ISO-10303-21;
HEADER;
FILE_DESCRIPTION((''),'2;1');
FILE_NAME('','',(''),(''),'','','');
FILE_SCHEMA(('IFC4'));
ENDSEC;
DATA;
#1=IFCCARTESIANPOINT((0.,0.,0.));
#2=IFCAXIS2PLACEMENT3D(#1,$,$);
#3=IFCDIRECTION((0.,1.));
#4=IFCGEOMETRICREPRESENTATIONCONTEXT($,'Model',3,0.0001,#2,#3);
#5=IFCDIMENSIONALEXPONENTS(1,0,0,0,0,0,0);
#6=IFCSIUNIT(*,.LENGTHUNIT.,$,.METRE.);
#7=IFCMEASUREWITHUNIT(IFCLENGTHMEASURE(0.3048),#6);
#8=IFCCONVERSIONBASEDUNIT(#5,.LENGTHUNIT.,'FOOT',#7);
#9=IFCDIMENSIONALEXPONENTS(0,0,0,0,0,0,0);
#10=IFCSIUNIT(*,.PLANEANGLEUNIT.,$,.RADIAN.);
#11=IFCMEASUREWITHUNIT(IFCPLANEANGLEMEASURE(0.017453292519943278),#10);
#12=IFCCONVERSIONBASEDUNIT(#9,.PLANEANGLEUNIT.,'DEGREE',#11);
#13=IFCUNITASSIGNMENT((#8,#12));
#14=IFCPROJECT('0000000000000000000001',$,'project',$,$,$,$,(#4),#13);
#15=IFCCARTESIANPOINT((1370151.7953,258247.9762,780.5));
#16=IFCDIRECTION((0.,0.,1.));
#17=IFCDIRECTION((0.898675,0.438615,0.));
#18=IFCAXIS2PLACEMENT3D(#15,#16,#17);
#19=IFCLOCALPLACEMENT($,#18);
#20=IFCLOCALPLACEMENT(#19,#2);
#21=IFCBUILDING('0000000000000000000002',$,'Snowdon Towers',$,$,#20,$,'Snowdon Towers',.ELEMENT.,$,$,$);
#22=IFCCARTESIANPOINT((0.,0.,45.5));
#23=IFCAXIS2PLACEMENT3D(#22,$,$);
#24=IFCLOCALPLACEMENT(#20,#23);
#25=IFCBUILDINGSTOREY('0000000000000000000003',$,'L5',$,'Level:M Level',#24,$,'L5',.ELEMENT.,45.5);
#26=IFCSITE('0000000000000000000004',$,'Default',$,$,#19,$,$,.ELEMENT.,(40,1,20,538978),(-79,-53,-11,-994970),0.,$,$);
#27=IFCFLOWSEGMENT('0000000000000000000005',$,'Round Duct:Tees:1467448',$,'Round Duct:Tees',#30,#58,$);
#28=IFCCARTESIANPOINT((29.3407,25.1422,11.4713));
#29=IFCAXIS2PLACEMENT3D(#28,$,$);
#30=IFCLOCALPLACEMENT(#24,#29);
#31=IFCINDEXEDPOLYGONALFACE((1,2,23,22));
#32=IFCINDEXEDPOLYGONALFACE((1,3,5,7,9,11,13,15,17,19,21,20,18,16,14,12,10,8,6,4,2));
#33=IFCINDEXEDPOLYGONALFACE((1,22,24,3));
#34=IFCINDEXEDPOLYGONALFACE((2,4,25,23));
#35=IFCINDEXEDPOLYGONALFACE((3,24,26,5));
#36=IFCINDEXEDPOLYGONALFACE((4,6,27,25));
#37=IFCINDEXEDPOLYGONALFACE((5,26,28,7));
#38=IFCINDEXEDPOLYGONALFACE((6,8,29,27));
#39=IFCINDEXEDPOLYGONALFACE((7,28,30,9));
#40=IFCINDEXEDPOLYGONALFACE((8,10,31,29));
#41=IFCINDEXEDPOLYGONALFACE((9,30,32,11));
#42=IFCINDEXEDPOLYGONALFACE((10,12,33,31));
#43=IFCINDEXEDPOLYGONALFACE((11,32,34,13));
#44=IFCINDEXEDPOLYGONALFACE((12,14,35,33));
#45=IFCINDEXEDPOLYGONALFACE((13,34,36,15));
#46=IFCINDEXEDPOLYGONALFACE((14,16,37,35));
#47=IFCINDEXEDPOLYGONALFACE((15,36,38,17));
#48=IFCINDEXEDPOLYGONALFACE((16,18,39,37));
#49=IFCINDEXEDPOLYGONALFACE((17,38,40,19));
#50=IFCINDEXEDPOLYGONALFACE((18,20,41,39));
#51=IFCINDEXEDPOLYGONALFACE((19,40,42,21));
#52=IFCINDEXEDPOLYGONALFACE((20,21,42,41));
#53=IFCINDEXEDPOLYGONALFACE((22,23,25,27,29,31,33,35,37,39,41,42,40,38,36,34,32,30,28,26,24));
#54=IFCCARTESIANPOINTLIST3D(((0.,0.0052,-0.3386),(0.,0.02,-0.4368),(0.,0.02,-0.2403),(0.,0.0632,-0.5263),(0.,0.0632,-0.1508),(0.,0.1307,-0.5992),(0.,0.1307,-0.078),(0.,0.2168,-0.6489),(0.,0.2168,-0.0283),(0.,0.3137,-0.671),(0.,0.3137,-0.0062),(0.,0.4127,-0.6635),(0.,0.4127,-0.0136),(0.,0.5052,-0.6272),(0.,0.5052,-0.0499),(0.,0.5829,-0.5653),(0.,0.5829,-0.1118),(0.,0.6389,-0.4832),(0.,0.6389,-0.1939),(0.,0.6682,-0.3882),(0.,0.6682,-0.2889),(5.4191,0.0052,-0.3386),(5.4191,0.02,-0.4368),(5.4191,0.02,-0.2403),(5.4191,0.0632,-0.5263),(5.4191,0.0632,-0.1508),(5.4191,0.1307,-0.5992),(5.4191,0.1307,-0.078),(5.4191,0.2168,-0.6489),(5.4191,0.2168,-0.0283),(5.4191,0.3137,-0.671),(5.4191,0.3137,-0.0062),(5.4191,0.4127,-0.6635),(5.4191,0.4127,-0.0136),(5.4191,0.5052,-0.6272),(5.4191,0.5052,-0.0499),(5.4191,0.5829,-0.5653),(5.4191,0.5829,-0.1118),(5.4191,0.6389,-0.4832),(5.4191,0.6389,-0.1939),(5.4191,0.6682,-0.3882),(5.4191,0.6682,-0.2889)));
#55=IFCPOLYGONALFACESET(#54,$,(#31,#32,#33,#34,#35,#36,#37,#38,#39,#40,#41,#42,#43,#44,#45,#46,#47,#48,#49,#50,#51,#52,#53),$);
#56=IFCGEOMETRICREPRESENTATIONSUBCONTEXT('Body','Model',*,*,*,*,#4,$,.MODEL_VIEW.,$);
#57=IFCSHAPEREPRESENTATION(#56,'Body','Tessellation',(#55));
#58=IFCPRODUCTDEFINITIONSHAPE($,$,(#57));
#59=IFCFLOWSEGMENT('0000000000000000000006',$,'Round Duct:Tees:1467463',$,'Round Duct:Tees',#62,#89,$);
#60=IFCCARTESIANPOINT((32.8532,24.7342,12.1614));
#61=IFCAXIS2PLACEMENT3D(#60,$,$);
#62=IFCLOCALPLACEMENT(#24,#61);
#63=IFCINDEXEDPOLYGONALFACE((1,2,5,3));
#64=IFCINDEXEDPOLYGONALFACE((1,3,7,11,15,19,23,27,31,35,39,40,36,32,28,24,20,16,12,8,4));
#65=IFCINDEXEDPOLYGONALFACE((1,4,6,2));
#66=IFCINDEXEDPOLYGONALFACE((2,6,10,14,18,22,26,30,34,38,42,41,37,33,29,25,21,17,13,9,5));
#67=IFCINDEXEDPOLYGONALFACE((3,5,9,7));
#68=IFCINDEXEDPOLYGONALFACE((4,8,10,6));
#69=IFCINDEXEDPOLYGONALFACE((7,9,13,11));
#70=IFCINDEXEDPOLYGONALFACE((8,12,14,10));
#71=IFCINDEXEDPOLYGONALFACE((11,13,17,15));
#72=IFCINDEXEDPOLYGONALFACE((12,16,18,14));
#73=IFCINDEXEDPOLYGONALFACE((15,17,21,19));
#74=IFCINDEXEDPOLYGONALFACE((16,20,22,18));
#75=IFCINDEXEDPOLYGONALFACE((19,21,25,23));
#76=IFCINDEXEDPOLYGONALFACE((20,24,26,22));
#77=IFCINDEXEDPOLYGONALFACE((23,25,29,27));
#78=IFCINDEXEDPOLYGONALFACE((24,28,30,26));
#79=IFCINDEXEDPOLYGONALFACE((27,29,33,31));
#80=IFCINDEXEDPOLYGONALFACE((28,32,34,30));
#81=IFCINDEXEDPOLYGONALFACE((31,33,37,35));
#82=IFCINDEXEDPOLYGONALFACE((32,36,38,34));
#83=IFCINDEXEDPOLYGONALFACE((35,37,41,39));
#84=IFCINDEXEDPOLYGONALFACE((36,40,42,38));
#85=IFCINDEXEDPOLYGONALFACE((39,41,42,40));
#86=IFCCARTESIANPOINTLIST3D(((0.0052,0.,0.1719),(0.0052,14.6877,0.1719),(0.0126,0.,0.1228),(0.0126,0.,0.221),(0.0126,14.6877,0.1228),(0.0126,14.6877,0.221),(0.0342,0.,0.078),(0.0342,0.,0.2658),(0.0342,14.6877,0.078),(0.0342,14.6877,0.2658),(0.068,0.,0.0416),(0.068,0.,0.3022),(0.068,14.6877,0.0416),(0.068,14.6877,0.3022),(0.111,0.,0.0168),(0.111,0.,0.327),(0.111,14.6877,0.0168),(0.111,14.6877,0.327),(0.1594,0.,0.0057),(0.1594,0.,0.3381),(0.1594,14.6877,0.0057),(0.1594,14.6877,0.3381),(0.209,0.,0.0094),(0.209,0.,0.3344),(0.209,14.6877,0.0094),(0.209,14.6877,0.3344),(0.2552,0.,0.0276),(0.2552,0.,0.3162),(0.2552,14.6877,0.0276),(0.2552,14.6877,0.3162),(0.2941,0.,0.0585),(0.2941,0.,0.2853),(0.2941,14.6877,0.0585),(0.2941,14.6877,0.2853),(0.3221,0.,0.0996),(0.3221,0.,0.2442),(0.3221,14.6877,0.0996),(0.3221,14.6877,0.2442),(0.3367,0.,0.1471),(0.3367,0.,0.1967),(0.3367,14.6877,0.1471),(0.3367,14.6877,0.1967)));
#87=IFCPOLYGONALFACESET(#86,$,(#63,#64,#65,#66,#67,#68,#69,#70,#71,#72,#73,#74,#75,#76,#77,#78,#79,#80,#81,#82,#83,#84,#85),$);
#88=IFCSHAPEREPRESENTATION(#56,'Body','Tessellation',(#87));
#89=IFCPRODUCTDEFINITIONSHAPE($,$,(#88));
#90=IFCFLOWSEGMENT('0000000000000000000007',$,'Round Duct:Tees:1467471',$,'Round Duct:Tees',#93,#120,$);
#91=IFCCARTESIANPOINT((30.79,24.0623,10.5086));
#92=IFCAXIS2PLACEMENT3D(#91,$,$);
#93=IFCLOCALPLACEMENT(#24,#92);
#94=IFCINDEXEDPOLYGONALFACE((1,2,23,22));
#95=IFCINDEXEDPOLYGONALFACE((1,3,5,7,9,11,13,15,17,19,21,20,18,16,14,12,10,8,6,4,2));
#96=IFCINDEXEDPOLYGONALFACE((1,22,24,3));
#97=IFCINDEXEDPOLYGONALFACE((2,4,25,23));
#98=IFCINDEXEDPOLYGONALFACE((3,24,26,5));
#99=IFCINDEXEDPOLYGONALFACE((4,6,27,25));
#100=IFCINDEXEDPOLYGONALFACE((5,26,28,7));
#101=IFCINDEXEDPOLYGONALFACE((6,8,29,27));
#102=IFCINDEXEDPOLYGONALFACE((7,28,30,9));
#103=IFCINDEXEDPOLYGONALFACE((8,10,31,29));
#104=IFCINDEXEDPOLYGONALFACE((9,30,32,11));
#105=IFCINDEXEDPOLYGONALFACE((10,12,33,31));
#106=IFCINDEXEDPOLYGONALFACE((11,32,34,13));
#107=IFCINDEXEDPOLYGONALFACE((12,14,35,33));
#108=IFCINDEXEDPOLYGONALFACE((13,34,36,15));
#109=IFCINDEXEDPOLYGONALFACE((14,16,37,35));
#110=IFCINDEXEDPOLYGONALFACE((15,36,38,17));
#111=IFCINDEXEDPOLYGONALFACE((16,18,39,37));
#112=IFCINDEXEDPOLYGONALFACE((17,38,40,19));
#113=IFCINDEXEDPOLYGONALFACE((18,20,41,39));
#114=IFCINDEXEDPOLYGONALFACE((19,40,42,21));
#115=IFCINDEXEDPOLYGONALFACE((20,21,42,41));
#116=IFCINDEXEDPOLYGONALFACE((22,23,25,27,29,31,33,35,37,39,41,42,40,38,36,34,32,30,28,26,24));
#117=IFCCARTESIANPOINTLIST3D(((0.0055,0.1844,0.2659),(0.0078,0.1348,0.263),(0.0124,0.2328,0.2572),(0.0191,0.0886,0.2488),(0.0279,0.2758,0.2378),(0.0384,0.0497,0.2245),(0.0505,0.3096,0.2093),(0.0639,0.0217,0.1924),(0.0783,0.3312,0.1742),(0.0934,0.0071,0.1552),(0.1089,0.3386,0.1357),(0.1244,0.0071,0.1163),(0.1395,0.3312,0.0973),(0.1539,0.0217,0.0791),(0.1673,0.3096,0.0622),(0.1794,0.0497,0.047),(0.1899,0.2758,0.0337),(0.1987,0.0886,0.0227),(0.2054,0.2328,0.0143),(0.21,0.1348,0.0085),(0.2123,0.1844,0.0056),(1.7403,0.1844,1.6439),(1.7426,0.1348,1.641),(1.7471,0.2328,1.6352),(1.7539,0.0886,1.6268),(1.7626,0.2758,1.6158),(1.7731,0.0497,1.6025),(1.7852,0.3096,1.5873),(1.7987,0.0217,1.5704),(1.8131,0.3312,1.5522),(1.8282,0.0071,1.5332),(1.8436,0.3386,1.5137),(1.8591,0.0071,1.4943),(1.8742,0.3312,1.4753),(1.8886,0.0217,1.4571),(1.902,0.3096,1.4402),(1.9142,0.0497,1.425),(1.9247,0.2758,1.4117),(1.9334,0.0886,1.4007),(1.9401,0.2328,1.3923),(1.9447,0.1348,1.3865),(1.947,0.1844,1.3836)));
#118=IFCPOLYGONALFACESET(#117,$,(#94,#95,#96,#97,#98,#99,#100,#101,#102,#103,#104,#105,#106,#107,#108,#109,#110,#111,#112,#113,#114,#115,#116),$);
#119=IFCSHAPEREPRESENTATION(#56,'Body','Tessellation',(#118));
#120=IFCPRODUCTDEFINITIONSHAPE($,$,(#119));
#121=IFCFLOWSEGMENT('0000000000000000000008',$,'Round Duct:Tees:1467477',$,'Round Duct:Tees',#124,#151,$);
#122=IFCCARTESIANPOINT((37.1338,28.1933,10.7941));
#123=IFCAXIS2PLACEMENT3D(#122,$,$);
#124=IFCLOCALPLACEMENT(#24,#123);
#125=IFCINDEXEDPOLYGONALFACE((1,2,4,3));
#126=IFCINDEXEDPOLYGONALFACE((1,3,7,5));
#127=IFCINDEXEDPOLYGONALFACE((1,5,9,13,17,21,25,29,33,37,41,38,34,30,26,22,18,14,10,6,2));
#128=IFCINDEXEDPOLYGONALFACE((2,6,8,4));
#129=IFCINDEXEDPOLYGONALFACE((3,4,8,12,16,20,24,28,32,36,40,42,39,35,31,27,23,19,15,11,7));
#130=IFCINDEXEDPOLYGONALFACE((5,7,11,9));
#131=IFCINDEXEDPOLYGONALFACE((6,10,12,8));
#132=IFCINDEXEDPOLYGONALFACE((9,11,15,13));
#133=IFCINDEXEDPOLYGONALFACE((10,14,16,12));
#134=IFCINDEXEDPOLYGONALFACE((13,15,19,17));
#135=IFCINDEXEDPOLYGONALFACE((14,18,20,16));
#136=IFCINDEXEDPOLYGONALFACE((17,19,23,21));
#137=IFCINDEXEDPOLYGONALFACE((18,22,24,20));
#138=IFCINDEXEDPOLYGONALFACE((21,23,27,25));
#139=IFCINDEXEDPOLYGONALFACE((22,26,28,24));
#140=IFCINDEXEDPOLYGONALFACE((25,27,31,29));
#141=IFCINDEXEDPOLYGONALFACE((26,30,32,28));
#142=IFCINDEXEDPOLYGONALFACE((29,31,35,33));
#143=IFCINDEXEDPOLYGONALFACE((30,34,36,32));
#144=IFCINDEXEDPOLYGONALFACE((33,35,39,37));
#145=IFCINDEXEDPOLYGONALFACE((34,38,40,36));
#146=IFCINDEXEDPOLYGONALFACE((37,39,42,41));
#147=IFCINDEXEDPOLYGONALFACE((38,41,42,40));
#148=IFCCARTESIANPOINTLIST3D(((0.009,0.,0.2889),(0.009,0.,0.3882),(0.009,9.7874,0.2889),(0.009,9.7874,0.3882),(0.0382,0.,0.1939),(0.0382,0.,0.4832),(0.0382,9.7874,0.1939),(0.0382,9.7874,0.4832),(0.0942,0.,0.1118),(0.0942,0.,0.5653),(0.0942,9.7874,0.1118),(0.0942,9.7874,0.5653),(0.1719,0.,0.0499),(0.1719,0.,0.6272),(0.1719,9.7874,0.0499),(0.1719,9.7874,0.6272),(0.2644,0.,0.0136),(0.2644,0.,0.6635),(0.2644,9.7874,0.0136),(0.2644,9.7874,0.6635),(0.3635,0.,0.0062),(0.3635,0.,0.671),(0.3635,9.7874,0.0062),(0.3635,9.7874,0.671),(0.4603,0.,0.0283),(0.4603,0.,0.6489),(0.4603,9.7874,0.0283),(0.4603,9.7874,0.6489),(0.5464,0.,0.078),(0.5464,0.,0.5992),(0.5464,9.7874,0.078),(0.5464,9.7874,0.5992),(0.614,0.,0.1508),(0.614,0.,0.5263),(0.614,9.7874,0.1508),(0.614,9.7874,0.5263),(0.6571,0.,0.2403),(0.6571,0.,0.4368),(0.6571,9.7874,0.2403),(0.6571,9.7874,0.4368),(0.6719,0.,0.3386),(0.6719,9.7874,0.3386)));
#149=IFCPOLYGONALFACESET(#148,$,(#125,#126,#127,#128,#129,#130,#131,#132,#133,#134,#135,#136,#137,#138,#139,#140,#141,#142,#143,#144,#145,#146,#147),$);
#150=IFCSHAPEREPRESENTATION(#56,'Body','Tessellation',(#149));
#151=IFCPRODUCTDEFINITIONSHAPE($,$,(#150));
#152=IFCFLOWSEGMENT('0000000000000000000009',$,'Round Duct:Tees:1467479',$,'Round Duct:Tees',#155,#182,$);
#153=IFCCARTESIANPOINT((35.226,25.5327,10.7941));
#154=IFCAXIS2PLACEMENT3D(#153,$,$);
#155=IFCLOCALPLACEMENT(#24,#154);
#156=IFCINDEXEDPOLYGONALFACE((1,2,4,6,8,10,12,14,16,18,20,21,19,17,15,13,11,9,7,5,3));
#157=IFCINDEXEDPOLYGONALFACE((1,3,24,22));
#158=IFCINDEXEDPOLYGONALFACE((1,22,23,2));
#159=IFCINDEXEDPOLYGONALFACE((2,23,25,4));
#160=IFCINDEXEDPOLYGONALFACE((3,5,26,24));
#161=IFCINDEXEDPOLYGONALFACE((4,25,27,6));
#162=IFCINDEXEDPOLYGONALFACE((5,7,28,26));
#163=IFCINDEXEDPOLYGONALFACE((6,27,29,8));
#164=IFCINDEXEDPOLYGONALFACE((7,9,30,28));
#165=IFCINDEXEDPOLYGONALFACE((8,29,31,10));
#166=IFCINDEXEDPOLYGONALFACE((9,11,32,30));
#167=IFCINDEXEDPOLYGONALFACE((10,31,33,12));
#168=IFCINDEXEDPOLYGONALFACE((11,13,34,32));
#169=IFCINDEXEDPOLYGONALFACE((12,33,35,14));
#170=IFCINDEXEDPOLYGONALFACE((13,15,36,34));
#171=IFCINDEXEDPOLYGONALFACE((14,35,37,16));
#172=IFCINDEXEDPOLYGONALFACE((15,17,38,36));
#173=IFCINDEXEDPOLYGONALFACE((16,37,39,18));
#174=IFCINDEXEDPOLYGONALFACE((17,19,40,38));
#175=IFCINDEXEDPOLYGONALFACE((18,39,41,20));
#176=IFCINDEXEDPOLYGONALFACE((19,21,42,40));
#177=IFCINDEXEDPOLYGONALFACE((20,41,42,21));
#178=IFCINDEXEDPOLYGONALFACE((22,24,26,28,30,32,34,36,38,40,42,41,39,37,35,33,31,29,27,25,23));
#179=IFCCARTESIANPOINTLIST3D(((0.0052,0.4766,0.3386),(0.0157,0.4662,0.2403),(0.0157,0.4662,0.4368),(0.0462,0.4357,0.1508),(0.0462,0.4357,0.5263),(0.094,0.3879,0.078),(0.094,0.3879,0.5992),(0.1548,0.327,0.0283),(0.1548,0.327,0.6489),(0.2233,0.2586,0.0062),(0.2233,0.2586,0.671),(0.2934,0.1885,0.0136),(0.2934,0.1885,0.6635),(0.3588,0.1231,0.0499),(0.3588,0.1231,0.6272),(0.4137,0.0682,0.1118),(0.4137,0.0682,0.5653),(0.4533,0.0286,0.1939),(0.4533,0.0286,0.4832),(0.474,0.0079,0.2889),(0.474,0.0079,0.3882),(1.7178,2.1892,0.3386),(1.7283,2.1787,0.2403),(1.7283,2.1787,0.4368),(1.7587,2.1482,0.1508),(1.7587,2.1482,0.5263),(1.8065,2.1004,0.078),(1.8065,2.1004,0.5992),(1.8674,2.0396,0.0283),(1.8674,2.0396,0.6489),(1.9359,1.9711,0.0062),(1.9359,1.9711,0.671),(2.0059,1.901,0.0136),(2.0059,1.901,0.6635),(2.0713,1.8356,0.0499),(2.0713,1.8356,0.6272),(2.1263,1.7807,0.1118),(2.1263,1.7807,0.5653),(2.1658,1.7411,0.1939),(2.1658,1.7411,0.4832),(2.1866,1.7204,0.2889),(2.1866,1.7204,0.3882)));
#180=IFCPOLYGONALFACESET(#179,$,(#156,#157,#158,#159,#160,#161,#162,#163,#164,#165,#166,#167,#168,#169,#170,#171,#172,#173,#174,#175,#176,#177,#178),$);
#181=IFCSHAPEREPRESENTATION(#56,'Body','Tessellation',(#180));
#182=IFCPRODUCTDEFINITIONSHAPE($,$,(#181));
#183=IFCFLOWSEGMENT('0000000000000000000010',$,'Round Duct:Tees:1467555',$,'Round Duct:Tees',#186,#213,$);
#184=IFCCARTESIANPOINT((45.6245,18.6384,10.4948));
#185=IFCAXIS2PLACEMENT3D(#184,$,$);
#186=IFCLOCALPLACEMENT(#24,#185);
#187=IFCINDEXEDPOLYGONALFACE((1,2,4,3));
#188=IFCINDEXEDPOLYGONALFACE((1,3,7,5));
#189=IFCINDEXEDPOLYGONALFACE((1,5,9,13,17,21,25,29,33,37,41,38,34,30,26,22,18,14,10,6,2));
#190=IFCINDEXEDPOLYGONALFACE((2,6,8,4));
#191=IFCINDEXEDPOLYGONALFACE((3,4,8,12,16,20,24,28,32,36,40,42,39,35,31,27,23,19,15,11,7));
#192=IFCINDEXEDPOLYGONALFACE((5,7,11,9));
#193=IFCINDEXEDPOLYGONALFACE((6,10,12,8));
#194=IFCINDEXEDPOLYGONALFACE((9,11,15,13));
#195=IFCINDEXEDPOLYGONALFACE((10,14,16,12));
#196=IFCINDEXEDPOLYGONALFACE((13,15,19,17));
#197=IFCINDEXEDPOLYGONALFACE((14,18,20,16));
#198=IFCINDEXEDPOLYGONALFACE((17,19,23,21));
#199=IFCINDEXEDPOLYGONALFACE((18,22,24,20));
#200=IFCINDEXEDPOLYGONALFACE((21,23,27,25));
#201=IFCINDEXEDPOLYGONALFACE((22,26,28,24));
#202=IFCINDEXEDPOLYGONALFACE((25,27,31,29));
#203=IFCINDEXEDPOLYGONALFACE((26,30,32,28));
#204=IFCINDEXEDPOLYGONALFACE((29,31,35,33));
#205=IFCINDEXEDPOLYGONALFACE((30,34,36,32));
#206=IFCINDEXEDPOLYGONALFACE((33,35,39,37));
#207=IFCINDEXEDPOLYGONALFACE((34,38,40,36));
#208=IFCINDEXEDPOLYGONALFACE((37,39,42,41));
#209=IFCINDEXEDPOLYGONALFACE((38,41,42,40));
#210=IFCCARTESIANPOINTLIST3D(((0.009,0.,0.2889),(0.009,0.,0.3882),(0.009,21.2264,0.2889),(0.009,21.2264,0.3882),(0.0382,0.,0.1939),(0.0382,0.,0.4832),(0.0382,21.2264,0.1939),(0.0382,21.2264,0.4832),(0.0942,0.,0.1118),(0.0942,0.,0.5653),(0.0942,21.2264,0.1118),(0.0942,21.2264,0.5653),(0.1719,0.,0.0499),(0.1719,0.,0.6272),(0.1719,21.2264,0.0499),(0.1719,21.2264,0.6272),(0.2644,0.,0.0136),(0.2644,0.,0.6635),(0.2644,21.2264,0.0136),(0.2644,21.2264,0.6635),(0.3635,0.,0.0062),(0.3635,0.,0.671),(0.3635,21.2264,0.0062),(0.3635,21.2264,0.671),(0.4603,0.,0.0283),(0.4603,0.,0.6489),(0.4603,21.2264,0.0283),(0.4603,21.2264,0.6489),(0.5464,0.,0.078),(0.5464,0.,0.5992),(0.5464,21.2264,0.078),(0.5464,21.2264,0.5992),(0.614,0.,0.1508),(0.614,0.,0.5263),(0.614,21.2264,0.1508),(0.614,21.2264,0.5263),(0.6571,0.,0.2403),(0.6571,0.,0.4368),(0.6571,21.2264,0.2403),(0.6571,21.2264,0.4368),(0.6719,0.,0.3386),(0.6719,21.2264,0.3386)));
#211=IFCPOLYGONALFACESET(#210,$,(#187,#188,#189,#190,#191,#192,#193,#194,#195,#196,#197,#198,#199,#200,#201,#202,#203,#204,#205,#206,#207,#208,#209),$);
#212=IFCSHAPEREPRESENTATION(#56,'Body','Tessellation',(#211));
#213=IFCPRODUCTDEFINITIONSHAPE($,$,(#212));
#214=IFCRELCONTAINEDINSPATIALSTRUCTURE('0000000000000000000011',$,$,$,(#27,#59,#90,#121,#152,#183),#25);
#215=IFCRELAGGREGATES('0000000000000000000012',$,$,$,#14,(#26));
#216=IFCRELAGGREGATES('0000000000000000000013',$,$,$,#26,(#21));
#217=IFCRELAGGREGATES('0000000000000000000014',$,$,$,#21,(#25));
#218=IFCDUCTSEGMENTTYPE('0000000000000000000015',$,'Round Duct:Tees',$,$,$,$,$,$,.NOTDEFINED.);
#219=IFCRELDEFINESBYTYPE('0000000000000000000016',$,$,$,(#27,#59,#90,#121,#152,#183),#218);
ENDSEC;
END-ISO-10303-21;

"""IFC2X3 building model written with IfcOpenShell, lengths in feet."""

from ifc_helpers import new_model, entity, si_unit, converted_unit, direction, frame, frame_2d, origin, origin_2d_with_axis, place, context, subcontext, project, spatial, circle, extrude, type_object, element, save


model = new_model("IFC2X3")

# Units and contexts
model_context = context("Model", 3, precision=0.0001, world=origin(), true_north=direction((0.0, 1.0)))
body_context = subcontext(model_context, "Body", "Model", "MODEL_VIEW")
ifc_project = project(units=[converted_unit("LENGTHUNIT", "FOOT", entity("IfcLengthMeasure", 0.3048), si_unit("LENGTHUNIT", "METRE"), dimensions=[1, 0, 0, 0, 0, 0, 0]), converted_unit("PLANEANGLEUNIT", "DEGREE", entity("IfcPlaneAngleMeasure", 0.017453292519943278), si_unit("PLANEANGLEUNIT", "RADIAN"), dimensions=[0, 0, 0, 0, 0, 0, 0])], contexts=[model_context])

# Site, building, storey
site_placement = place(None, frame((1370151.7953, 258247.9762, 780.5), z_axis=(0.0, 0.0, 1.0), x_axis=(0.898675, 0.438615, 0.0)))
site = spatial("IfcSite", under=ifc_project, at=site_placement, Name="Default", CompositionType="ELEMENT", RefLatitude=(40, 1, 20, 538978), RefLongitude=(-79, -53, -11, -994970), RefElevation=0.0)
building_placement = place(site_placement, origin())
building = spatial("IfcBuilding", under=site, at=building_placement, Name="Snowdon Towers", LongName="Snowdon Towers", CompositionType="ELEMENT")
storey_placement = place(building_placement, frame((0.0, 0.0, 45.5)))
storey = spatial("IfcBuildingStorey", under=building, at=storey_placement, Name="L5", ObjectType="Level:M Level", LongName="L5", CompositionType="ELEMENT", Elevation=45.5)

# Flow segments
duct_segment_type = type_object("IfcDuctSegmentType", Name="Round Duct:Tees", PredefinedType="NOTDEFINED")
flow_segment_1_placement = place(storey_placement, frame((29.3407, 25.1422, 11.4713)))
element("IfcFlowSegment", 1, at=flow_segment_1_placement, inside=storey, type_object=duct_segment_type, Name="Round Duct:Tees:1467448", ObjectType="Round Duct:Tees", context=body_context, shape_type="SweptSolid", body=[
    extrude(circle(Radius=0.3333, at=frame_2d((0.0, 0.0), x_axis=(1.0, 0.0))), frame((0.0, 0.3386, -0.3386), z_axis=(1.0, 0.0, 0.0), x_axis=(0.0, -1.0, 0.0)), (0.0, 0.0, 1.0), 5.4191),
])
flow_segment_2_placement = place(storey_placement, frame((32.8532, 24.7342, 12.1614)))
element("IfcFlowSegment", 2, at=flow_segment_2_placement, inside=storey, type_object=duct_segment_type, Name="Round Duct:Tees:1467463", ObjectType="Round Duct:Tees", context=body_context, shape_type="SweptSolid", body=[
    extrude(circle(Radius=0.1667, at=frame_2d((0.0, 0.0), x_axis=(1.0, 0.0))), frame((0.1719, 0.0, 0.1719), z_axis=(0.0, 1.0, 0.0), x_axis=(-1.0, 0.0, 0.0)), (0.0, 0.0, 1.0), 14.6877),
])
flow_segment_3_placement = place(storey_placement, frame((30.79, 24.0623, 10.5086)))
element("IfcFlowSegment", 3, at=flow_segment_3_placement, inside=storey, type_object=duct_segment_type, Name="Round Duct:Tees:1467471", ObjectType="Round Duct:Tees", context=body_context, shape_type="SweptSolid", body=[
    extrude(circle(Radius=0.1667, at=frame_2d((0.0, 0.0), x_axis=(1.0, 0.0))), frame((0.1089, 0.1719, 0.1357), z_axis=(0.78302, 0.0, 0.621996), x_axis=(0.0, 1.0, 0.0)), (0.0, 0.0, 1.0), 2.2155),
])
flow_segment_4_placement = place(storey_placement, frame((37.1338, 28.1933, 10.7941)))
element("IfcFlowSegment", 4, at=flow_segment_4_placement, inside=storey, type_object=duct_segment_type, Name="Round Duct:Tees:1467477", ObjectType="Round Duct:Tees", context=body_context, shape_type="SweptSolid", body=[
    extrude(circle(Radius=0.3333, at=frame_2d((0.0, 0.0), x_axis=(1.0, 0.0))), frame((0.3386, 0.0, 0.3386), z_axis=(0.0, 1.0, 0.0), x_axis=(1.0, 0.0, 0.0)), (0.0, 0.0, 1.0), 9.7874),
])
flow_segment_5_placement = place(storey_placement, frame((35.226, 25.5327, 10.7941)))
element("IfcFlowSegment", 5, at=flow_segment_5_placement, inside=storey, type_object=duct_segment_type, Name="Round Duct:Tees:1467479", ObjectType="Round Duct:Tees", context=body_context, shape_type="SweptSolid", body=[
    extrude(circle(Radius=0.3333, at=origin_2d_with_axis()), frame((0.2409, 0.2409, 0.3386), z_axis=(0.707107, 0.707107, 0.0), x_axis=(-0.707107, 0.707107, 0.0)), (0.0, 0.0, 1.0), 2.4219),
])
flow_segment_6_placement = place(storey_placement, frame((45.6245, 18.6384, 10.4948)))
element("IfcFlowSegment", 6, at=flow_segment_6_placement, inside=storey, type_object=duct_segment_type, Name="Round Duct:Tees:1467555", ObjectType="Round Duct:Tees", context=body_context, shape_type="SweptSolid", body=[
    extrude(circle(Radius=0.3333, at=frame_2d((0.0, 0.0), x_axis=(1.0, 0.0))), frame((0.3386, 0.0, 0.3386), z_axis=(0.0, 1.0, 0.0), x_axis=(1.0, 0.0, 0.0)), (0.0, 0.0, 1.0), 21.2264),
])

save(model, "model.ifc")
